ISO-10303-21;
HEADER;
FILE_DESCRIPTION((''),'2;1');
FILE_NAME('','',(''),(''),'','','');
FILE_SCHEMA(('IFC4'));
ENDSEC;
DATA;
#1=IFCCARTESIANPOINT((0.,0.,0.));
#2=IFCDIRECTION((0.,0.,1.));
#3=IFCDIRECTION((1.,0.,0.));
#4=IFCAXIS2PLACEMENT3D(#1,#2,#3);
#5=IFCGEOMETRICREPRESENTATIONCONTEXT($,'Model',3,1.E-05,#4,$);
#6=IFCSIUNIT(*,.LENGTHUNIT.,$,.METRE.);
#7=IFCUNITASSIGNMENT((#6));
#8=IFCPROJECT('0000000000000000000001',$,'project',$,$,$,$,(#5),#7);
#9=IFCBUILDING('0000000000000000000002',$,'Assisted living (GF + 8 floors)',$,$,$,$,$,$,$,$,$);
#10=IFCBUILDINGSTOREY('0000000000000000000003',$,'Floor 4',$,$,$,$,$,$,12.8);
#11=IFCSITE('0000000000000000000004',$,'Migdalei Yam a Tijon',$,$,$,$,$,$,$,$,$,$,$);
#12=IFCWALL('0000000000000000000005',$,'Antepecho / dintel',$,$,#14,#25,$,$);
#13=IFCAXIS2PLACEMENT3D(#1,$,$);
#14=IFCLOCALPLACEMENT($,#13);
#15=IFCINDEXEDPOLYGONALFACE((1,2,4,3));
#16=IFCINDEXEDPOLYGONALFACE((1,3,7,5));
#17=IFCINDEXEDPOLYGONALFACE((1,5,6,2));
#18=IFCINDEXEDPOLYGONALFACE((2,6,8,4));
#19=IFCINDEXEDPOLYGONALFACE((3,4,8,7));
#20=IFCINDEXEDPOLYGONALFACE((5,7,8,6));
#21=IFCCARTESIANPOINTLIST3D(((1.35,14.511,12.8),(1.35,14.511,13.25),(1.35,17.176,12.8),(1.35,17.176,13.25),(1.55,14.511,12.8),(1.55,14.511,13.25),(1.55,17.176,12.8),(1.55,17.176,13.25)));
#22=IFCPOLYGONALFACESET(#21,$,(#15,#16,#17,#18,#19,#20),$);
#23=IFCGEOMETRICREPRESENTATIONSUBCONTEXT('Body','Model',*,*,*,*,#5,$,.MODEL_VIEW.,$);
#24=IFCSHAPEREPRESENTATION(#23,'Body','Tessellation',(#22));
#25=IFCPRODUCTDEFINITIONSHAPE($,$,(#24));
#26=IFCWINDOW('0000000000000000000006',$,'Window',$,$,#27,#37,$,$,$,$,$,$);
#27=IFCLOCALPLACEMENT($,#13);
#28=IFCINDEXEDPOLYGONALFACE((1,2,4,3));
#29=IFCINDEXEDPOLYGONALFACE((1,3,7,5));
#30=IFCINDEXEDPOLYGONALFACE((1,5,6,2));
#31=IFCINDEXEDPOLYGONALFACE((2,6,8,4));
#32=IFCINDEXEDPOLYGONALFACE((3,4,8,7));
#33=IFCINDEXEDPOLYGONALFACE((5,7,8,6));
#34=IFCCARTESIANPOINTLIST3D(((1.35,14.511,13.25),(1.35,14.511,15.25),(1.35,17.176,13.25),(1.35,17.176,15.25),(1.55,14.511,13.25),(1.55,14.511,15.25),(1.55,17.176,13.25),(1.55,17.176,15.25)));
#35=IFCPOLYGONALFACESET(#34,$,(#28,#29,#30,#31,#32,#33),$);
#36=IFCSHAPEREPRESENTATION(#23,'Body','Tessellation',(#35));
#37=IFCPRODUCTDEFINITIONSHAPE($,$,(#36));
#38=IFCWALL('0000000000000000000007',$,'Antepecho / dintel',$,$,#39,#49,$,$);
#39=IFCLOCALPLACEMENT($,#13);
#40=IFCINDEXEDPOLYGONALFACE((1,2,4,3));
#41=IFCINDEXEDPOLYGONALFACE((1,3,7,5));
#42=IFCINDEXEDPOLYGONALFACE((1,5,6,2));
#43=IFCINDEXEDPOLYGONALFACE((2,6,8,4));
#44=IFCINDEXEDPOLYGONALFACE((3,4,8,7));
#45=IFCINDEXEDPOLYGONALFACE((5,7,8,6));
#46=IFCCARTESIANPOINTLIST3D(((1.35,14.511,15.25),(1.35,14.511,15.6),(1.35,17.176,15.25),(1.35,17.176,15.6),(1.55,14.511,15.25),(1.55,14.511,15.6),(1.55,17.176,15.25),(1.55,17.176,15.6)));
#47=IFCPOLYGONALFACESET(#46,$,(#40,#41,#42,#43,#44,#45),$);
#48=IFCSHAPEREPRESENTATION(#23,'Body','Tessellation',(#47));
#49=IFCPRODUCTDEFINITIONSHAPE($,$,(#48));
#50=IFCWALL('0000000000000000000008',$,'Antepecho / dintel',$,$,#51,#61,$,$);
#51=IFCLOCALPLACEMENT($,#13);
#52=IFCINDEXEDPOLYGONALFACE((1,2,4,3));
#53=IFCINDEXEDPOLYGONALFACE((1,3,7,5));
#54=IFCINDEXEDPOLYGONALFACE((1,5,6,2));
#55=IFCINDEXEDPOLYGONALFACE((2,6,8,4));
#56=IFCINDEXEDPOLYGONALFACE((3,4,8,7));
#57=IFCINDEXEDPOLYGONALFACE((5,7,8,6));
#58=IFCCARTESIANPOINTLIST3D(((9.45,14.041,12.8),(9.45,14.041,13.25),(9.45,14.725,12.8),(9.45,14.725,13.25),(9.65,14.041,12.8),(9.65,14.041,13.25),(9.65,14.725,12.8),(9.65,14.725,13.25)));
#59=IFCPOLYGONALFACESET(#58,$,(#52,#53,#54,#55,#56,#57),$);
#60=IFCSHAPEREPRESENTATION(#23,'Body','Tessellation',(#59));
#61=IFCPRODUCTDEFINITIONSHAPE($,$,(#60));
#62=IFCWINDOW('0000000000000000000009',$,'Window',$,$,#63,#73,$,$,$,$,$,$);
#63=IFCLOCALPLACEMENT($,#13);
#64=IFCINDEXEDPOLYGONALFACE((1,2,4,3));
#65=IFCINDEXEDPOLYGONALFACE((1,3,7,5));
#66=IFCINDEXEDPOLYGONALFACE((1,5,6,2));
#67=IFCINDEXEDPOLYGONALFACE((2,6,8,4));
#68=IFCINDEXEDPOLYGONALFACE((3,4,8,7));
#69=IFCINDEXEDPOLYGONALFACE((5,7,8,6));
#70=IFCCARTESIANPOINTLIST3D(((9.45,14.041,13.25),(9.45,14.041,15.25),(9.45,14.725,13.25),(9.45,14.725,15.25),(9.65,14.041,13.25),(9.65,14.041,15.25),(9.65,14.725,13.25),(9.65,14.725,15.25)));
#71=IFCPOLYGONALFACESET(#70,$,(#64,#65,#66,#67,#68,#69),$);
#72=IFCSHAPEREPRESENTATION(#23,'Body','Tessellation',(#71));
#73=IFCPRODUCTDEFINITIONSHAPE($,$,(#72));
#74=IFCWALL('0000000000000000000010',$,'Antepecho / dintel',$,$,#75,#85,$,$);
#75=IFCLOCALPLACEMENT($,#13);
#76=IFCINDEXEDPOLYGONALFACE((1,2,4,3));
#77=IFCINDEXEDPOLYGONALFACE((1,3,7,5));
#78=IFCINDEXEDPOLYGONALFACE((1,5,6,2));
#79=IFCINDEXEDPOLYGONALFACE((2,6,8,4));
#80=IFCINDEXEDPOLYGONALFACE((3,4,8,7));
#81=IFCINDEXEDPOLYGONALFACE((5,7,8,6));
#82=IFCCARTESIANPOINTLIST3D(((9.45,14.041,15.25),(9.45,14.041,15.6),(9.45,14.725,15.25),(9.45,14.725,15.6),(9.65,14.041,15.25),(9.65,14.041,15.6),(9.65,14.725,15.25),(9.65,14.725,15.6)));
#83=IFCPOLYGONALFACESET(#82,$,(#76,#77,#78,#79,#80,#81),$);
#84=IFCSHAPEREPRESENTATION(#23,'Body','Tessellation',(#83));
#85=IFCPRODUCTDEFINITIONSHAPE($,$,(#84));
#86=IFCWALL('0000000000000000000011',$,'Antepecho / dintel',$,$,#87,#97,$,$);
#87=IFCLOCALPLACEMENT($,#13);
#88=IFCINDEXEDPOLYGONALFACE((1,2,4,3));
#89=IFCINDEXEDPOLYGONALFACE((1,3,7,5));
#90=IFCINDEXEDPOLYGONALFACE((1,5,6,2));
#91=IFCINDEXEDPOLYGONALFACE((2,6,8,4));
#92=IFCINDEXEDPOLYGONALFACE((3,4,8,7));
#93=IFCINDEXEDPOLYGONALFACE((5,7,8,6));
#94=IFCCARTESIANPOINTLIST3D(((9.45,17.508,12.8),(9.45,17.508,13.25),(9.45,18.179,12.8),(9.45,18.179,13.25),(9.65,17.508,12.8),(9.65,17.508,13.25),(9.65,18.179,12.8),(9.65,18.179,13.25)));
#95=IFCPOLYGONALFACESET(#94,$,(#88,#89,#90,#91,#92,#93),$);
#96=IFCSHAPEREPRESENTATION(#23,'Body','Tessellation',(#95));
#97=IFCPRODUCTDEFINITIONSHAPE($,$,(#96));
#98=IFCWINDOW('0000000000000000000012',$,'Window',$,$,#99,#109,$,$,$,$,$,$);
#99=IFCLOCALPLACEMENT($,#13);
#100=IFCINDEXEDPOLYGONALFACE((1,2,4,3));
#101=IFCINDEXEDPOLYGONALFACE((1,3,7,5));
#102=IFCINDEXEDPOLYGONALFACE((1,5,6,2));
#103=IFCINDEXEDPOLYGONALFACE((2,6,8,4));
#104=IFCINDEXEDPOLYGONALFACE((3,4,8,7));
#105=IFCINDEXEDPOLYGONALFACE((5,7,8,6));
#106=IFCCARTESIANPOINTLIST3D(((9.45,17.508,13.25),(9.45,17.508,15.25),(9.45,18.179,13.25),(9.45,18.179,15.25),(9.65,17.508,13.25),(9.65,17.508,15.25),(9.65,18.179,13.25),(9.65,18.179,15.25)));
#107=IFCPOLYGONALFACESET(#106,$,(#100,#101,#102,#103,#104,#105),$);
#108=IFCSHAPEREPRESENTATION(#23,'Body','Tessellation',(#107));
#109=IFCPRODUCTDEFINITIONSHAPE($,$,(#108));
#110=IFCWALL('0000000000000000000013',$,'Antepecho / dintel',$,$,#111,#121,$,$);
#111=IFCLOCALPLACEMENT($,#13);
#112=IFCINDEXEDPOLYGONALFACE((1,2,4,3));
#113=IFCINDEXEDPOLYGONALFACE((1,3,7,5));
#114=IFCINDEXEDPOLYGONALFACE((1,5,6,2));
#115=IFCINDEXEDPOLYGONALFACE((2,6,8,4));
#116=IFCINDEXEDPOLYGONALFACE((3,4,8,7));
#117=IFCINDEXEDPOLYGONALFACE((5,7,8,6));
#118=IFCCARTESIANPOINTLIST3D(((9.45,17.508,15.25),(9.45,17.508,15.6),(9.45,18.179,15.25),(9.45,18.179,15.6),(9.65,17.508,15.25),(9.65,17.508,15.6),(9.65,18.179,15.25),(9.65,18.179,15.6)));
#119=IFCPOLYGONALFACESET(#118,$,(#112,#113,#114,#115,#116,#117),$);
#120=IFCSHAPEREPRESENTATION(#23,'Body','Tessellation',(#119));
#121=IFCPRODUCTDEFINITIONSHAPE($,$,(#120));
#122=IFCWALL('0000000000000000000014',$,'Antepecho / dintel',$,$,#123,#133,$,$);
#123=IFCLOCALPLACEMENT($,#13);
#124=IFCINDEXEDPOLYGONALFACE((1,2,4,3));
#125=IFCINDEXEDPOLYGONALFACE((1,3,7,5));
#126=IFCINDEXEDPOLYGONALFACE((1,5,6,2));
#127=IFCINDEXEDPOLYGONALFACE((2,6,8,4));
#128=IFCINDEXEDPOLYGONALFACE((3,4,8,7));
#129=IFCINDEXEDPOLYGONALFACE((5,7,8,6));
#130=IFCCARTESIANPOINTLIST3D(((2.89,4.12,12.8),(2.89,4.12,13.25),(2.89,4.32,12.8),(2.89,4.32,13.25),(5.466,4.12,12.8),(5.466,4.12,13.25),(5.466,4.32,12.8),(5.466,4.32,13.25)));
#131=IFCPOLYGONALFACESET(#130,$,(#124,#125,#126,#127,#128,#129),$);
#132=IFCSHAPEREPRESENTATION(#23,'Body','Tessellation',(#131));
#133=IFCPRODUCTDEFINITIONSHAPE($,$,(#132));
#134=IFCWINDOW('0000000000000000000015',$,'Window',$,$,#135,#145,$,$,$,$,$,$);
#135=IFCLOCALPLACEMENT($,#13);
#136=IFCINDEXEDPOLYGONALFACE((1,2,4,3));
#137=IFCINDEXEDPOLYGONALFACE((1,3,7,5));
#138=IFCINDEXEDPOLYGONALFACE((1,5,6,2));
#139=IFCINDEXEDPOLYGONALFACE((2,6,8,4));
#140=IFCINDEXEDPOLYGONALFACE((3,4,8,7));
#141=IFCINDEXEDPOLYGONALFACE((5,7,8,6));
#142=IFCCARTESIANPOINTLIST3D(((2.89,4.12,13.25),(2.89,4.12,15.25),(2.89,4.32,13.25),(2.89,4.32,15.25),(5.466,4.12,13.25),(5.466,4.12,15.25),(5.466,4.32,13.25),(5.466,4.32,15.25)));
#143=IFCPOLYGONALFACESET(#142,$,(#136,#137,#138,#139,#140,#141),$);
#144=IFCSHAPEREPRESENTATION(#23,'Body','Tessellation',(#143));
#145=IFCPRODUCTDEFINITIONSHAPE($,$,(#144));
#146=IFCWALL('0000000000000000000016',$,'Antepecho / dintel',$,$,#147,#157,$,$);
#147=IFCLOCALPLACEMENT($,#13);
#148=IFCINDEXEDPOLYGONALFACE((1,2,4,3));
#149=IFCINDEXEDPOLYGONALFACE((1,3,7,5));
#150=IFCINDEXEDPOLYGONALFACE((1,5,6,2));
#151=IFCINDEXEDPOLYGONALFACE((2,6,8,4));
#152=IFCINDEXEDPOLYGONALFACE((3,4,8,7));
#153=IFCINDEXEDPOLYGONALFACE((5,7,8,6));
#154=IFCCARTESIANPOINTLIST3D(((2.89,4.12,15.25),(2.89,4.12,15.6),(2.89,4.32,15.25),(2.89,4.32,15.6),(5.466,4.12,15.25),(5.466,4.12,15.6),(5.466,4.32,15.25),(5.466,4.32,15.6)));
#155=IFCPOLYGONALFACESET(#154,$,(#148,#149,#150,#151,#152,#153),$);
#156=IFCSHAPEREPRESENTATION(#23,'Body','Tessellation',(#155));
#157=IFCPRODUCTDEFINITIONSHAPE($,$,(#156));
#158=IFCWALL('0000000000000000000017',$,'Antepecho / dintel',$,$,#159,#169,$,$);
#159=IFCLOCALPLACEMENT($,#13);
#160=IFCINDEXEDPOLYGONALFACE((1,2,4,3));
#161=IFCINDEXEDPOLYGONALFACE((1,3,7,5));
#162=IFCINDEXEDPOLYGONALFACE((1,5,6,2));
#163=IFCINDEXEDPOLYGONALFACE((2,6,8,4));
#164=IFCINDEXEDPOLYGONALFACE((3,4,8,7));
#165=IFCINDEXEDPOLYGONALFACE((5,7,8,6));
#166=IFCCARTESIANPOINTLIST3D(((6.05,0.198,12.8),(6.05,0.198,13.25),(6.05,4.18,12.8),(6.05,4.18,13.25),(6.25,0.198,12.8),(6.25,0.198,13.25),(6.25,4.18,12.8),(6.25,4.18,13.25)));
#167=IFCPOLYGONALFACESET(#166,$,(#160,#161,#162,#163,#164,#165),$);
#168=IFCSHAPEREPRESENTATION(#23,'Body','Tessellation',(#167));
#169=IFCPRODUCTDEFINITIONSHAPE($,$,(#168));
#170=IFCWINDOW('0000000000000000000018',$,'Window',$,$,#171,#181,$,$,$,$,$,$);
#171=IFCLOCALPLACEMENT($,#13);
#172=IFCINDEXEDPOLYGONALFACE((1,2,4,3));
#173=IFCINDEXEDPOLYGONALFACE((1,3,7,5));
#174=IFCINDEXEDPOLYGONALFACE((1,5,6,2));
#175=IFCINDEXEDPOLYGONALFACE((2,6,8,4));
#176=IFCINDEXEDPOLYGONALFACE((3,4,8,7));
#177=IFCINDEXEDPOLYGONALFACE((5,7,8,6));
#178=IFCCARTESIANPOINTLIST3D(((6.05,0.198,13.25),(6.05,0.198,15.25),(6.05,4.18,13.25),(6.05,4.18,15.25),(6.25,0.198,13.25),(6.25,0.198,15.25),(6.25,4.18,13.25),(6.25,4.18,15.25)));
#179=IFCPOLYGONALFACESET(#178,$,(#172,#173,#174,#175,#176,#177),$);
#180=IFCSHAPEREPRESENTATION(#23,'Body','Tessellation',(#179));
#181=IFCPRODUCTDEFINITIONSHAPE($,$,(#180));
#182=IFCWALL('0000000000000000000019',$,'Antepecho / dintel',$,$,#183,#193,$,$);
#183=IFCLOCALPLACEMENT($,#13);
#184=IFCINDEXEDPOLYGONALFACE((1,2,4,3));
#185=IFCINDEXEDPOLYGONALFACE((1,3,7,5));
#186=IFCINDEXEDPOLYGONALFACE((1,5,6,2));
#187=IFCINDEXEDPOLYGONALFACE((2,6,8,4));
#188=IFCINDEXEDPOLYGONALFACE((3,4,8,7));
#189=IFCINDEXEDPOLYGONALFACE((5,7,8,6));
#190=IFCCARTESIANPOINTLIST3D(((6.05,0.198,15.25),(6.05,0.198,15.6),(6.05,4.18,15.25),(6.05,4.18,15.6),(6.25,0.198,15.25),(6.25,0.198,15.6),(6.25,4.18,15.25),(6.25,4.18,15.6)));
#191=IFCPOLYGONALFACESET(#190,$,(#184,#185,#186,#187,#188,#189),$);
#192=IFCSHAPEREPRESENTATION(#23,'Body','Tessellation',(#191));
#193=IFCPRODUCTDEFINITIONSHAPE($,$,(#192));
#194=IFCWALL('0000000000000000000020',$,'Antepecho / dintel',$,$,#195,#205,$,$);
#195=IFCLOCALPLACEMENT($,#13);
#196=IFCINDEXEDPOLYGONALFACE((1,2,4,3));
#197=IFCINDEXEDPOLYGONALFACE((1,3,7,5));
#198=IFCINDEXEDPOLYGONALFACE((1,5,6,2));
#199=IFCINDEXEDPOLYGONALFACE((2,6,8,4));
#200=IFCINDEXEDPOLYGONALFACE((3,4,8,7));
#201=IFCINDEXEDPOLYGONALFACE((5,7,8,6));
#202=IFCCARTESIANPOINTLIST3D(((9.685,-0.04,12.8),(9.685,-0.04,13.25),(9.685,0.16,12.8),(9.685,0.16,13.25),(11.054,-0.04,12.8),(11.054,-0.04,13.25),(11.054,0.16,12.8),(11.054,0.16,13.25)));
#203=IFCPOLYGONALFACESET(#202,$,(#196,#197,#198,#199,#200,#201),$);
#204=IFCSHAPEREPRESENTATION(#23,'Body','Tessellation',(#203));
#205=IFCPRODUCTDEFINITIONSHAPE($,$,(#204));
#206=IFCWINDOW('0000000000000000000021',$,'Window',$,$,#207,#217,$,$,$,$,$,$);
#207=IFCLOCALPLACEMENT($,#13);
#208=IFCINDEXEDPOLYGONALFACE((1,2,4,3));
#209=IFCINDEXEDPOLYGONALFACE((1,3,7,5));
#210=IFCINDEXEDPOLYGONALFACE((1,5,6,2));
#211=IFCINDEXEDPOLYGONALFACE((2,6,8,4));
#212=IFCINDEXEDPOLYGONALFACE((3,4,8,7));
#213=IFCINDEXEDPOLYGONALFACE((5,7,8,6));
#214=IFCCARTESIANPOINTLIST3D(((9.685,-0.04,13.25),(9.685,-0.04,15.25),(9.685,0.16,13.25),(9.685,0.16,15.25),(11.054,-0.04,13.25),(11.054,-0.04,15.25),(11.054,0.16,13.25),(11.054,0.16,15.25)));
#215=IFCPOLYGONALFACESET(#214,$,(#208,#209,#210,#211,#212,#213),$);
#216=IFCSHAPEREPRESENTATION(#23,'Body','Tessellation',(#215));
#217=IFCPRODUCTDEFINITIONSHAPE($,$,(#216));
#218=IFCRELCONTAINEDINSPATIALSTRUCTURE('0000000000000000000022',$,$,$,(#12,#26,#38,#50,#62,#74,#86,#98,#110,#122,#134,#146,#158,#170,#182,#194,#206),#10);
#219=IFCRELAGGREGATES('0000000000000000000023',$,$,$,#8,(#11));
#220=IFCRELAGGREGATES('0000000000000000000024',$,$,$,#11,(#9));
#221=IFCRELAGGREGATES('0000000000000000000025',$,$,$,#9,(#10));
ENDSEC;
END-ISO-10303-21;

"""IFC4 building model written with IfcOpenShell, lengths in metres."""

from ifc_helpers import new_model, si_unit, frame, origin_with_axes, context, subcontext, project, spatial, line, indexed_curve, outline, extrude, element, save


model = new_model("IFC4")

# Units and contexts
model_context = context("Model", 3, precision=1e-05, world=origin_with_axes())
body_context = subcontext(model_context, "Body", "Model", "MODEL_VIEW")
ifc_project = project(units=[si_unit("LENGTHUNIT", "METRE")], contexts=[model_context])

# Site, building, storey
site = spatial("IfcSite", under=ifc_project, Name="Migdalei Yam a Tijon")
building = spatial("IfcBuilding", under=site, Name="Assisted living (GF + 8 floors)")
storey = spatial("IfcBuildingStorey", under=building, Name="Floor 4", Elevation=12.8)

# Wall
element("IfcWall", 1, inside=storey, Name="Antepecho / dintel", context=body_context, shape_type="SweptSolid", body=[
    extrude(outline(indexed_curve([(0.0, 0.0), (0.2, 0.0), (0.2, 2.665), (0.0, 2.665)], segments=[line(1, 2, 3, 4, 1)])), frame((1.35, 14.511, 12.8), z_axis=(0.0, 0.0, 1.0), x_axis=(1.0, 0.0, 0.0)), (0.0, 0.0, 1.0), 0.45),
])

# Window
element("IfcWindow", 2, inside=storey, Name="Window", context=body_context, shape_type="SweptSolid", body=[
    extrude(outline(indexed_curve([(0.0, 0.0), (0.2, 0.0), (0.2, 2.665), (0.0, 2.665)], segments=[line(1, 2, 3, 4, 1)])), frame((1.35, 14.511, 13.25), z_axis=(0.0, 0.0, 1.0), x_axis=(1.0, 0.0, 0.0)), (0.0, 0.0, 1.0), 2.0),
])

# Walls
element("IfcWall", 3, inside=storey, Name="Antepecho / dintel", context=body_context, shape_type="SweptSolid", body=[
    extrude(outline(indexed_curve([(0.0, 0.0), (0.2, 0.0), (0.2, 2.665), (0.0, 2.665)], segments=[line(1, 2, 3, 4, 1)])), frame((1.35, 14.511, 15.25), z_axis=(0.0, 0.0, 1.0), x_axis=(1.0, 0.0, 0.0)), (0.0, 0.0, 1.0), 0.35),
])
element("IfcWall", 4, inside=storey, Name="Antepecho / dintel", context=body_context, shape_type="SweptSolid", body=[
    extrude(outline(indexed_curve([(0.0, 0.0), (0.2, 0.0), (0.2, 0.684), (0.0, 0.684)], segments=[line(1, 2, 3, 4, 1)])), frame((9.45, 14.041, 12.8), z_axis=(0.0, 0.0, 1.0), x_axis=(1.0, 0.0, 0.0)), (0.0, 0.0, 1.0), 0.45),
])

# Window
element("IfcWindow", 5, inside=storey, Name="Window", context=body_context, shape_type="SweptSolid", body=[
    extrude(outline(indexed_curve([(0.0, 0.0), (0.2, 0.0), (0.2, 0.684), (0.0, 0.684)], segments=[line(1, 2, 3, 4, 1)])), frame((9.45, 14.041, 13.25), z_axis=(0.0, 0.0, 1.0), x_axis=(1.0, 0.0, 0.0)), (0.0, 0.0, 1.0), 2.0),
])

# Walls
element("IfcWall", 6, inside=storey, Name="Antepecho / dintel", context=body_context, shape_type="SweptSolid", body=[
    extrude(outline(indexed_curve([(0.0, 0.0), (0.2, 0.0), (0.2, 0.684), (0.0, 0.684)], segments=[line(1, 2, 3, 4, 1)])), frame((9.45, 14.041, 15.25), z_axis=(0.0, 0.0, 1.0), x_axis=(1.0, 0.0, 0.0)), (0.0, 0.0, 1.0), 0.35),
])
element("IfcWall", 7, inside=storey, Name="Antepecho / dintel", context=body_context, shape_type="SweptSolid", body=[
    extrude(outline(indexed_curve([(0.0, 0.0), (0.2, 0.0), (0.2, 0.671), (0.0, 0.671)], segments=[line(1, 2, 3, 4, 1)])), frame((9.45, 17.508, 12.8), z_axis=(0.0, 0.0, 1.0), x_axis=(1.0, 0.0, 0.0)), (0.0, 0.0, 1.0), 0.45),
])

# Window
element("IfcWindow", 8, inside=storey, Name="Window", context=body_context, shape_type="SweptSolid", body=[
    extrude(outline(indexed_curve([(0.0, 0.0), (0.2, 0.0), (0.2, 0.671), (0.0, 0.671)], segments=[line(1, 2, 3, 4, 1)])), frame((9.45, 17.508, 13.25), z_axis=(0.0, 0.0, 1.0), x_axis=(1.0, 0.0, 0.0)), (0.0, 0.0, 1.0), 2.0),
])

# Walls
element("IfcWall", 9, inside=storey, Name="Antepecho / dintel", context=body_context, shape_type="SweptSolid", body=[
    extrude(outline(indexed_curve([(0.0, 0.0), (0.2, 0.0), (0.2, 0.671), (0.0, 0.671)], segments=[line(1, 2, 3, 4, 1)])), frame((9.45, 17.508, 15.25), z_axis=(0.0, 0.0, 1.0), x_axis=(1.0, 0.0, 0.0)), (0.0, 0.0, 1.0), 0.35),
])
element("IfcWall", 10, inside=storey, Name="Antepecho / dintel", context=body_context, shape_type="SweptSolid", body=[
    extrude(outline(indexed_curve([(0.0, 0.0), (2.576, 0.0), (2.576, 0.2), (0.0, 0.2)], segments=[line(1, 2, 3, 4, 1)])), frame((2.89, 4.12, 12.8), z_axis=(0.0, 0.0, 1.0), x_axis=(1.0, 0.0, 0.0)), (0.0, 0.0, 1.0), 0.45),
])

# Window
element("IfcWindow", 11, inside=storey, Name="Window", context=body_context, shape_type="SweptSolid", body=[
    extrude(outline(indexed_curve([(0.0, 0.0), (2.576, 0.0), (2.576, 0.2), (0.0, 0.2)], segments=[line(1, 2, 3, 4, 1)])), frame((2.89, 4.12, 13.25), z_axis=(0.0, 0.0, 1.0), x_axis=(1.0, 0.0, 0.0)), (0.0, 0.0, 1.0), 2.0),
])

# Walls
element("IfcWall", 12, inside=storey, Name="Antepecho / dintel", context=body_context, shape_type="SweptSolid", body=[
    extrude(outline(indexed_curve([(0.0, 0.0), (2.576, 0.0), (2.576, 0.2), (0.0, 0.2)], segments=[line(1, 2, 3, 4, 1)])), frame((2.89, 4.12, 15.25), z_axis=(0.0, 0.0, 1.0), x_axis=(1.0, 0.0, 0.0)), (0.0, 0.0, 1.0), 0.35),
])
element("IfcWall", 13, inside=storey, Name="Antepecho / dintel", context=body_context, shape_type="SweptSolid", body=[
    extrude(outline(indexed_curve([(0.0, 0.0), (0.2, 0.0), (0.2, 3.982), (0.0, 3.982)], segments=[line(1, 2, 3, 4, 1)])), frame((6.05, 0.198, 12.8), z_axis=(0.0, 0.0, 1.0), x_axis=(1.0, 0.0, 0.0)), (0.0, 0.0, 1.0), 0.45),
])

# Window
element("IfcWindow", 14, inside=storey, Name="Window", context=body_context, shape_type="SweptSolid", body=[
    extrude(outline(indexed_curve([(0.0, 0.0), (0.2, 0.0), (0.2, 3.982), (0.0, 3.982)], segments=[line(1, 2, 3, 4, 1)])), frame((6.05, 0.198, 13.25), z_axis=(0.0, 0.0, 1.0), x_axis=(1.0, 0.0, 0.0)), (0.0, 0.0, 1.0), 2.0),
])

# Walls
element("IfcWall", 15, inside=storey, Name="Antepecho / dintel", context=body_context, shape_type="SweptSolid", body=[
    extrude(outline(indexed_curve([(0.0, 0.0), (0.2, 0.0), (0.2, 3.982), (0.0, 3.982)], segments=[line(1, 2, 3, 4, 1)])), frame((6.05, 0.198, 15.25), z_axis=(0.0, 0.0, 1.0), x_axis=(1.0, 0.0, 0.0)), (0.0, 0.0, 1.0), 0.35),
])
element("IfcWall", 16, inside=storey, Name="Antepecho / dintel", context=body_context, shape_type="SweptSolid", body=[
    extrude(outline(indexed_curve([(0.0, 0.0), (1.369, 0.0), (1.369, 0.2), (0.0, 0.2)], segments=[line(1, 2, 3, 4, 1)])), frame((9.685, -0.04, 12.8), z_axis=(0.0, 0.0, 1.0), x_axis=(1.0, 0.0, 0.0)), (0.0, 0.0, 1.0), 0.45),
])

# Window
element("IfcWindow", 17, inside=storey, Name="Window", context=body_context, shape_type="SweptSolid", body=[
    extrude(outline(indexed_curve([(0.0, 0.0), (1.369, 0.0), (1.369, 0.2), (0.0, 0.2)], segments=[line(1, 2, 3, 4, 1)])), frame((9.685, -0.04, 13.25), z_axis=(0.0, 0.0, 1.0), x_axis=(1.0, 0.0, 0.0)), (0.0, 0.0, 1.0), 2.0),
])

save(model, "model.ifc")
